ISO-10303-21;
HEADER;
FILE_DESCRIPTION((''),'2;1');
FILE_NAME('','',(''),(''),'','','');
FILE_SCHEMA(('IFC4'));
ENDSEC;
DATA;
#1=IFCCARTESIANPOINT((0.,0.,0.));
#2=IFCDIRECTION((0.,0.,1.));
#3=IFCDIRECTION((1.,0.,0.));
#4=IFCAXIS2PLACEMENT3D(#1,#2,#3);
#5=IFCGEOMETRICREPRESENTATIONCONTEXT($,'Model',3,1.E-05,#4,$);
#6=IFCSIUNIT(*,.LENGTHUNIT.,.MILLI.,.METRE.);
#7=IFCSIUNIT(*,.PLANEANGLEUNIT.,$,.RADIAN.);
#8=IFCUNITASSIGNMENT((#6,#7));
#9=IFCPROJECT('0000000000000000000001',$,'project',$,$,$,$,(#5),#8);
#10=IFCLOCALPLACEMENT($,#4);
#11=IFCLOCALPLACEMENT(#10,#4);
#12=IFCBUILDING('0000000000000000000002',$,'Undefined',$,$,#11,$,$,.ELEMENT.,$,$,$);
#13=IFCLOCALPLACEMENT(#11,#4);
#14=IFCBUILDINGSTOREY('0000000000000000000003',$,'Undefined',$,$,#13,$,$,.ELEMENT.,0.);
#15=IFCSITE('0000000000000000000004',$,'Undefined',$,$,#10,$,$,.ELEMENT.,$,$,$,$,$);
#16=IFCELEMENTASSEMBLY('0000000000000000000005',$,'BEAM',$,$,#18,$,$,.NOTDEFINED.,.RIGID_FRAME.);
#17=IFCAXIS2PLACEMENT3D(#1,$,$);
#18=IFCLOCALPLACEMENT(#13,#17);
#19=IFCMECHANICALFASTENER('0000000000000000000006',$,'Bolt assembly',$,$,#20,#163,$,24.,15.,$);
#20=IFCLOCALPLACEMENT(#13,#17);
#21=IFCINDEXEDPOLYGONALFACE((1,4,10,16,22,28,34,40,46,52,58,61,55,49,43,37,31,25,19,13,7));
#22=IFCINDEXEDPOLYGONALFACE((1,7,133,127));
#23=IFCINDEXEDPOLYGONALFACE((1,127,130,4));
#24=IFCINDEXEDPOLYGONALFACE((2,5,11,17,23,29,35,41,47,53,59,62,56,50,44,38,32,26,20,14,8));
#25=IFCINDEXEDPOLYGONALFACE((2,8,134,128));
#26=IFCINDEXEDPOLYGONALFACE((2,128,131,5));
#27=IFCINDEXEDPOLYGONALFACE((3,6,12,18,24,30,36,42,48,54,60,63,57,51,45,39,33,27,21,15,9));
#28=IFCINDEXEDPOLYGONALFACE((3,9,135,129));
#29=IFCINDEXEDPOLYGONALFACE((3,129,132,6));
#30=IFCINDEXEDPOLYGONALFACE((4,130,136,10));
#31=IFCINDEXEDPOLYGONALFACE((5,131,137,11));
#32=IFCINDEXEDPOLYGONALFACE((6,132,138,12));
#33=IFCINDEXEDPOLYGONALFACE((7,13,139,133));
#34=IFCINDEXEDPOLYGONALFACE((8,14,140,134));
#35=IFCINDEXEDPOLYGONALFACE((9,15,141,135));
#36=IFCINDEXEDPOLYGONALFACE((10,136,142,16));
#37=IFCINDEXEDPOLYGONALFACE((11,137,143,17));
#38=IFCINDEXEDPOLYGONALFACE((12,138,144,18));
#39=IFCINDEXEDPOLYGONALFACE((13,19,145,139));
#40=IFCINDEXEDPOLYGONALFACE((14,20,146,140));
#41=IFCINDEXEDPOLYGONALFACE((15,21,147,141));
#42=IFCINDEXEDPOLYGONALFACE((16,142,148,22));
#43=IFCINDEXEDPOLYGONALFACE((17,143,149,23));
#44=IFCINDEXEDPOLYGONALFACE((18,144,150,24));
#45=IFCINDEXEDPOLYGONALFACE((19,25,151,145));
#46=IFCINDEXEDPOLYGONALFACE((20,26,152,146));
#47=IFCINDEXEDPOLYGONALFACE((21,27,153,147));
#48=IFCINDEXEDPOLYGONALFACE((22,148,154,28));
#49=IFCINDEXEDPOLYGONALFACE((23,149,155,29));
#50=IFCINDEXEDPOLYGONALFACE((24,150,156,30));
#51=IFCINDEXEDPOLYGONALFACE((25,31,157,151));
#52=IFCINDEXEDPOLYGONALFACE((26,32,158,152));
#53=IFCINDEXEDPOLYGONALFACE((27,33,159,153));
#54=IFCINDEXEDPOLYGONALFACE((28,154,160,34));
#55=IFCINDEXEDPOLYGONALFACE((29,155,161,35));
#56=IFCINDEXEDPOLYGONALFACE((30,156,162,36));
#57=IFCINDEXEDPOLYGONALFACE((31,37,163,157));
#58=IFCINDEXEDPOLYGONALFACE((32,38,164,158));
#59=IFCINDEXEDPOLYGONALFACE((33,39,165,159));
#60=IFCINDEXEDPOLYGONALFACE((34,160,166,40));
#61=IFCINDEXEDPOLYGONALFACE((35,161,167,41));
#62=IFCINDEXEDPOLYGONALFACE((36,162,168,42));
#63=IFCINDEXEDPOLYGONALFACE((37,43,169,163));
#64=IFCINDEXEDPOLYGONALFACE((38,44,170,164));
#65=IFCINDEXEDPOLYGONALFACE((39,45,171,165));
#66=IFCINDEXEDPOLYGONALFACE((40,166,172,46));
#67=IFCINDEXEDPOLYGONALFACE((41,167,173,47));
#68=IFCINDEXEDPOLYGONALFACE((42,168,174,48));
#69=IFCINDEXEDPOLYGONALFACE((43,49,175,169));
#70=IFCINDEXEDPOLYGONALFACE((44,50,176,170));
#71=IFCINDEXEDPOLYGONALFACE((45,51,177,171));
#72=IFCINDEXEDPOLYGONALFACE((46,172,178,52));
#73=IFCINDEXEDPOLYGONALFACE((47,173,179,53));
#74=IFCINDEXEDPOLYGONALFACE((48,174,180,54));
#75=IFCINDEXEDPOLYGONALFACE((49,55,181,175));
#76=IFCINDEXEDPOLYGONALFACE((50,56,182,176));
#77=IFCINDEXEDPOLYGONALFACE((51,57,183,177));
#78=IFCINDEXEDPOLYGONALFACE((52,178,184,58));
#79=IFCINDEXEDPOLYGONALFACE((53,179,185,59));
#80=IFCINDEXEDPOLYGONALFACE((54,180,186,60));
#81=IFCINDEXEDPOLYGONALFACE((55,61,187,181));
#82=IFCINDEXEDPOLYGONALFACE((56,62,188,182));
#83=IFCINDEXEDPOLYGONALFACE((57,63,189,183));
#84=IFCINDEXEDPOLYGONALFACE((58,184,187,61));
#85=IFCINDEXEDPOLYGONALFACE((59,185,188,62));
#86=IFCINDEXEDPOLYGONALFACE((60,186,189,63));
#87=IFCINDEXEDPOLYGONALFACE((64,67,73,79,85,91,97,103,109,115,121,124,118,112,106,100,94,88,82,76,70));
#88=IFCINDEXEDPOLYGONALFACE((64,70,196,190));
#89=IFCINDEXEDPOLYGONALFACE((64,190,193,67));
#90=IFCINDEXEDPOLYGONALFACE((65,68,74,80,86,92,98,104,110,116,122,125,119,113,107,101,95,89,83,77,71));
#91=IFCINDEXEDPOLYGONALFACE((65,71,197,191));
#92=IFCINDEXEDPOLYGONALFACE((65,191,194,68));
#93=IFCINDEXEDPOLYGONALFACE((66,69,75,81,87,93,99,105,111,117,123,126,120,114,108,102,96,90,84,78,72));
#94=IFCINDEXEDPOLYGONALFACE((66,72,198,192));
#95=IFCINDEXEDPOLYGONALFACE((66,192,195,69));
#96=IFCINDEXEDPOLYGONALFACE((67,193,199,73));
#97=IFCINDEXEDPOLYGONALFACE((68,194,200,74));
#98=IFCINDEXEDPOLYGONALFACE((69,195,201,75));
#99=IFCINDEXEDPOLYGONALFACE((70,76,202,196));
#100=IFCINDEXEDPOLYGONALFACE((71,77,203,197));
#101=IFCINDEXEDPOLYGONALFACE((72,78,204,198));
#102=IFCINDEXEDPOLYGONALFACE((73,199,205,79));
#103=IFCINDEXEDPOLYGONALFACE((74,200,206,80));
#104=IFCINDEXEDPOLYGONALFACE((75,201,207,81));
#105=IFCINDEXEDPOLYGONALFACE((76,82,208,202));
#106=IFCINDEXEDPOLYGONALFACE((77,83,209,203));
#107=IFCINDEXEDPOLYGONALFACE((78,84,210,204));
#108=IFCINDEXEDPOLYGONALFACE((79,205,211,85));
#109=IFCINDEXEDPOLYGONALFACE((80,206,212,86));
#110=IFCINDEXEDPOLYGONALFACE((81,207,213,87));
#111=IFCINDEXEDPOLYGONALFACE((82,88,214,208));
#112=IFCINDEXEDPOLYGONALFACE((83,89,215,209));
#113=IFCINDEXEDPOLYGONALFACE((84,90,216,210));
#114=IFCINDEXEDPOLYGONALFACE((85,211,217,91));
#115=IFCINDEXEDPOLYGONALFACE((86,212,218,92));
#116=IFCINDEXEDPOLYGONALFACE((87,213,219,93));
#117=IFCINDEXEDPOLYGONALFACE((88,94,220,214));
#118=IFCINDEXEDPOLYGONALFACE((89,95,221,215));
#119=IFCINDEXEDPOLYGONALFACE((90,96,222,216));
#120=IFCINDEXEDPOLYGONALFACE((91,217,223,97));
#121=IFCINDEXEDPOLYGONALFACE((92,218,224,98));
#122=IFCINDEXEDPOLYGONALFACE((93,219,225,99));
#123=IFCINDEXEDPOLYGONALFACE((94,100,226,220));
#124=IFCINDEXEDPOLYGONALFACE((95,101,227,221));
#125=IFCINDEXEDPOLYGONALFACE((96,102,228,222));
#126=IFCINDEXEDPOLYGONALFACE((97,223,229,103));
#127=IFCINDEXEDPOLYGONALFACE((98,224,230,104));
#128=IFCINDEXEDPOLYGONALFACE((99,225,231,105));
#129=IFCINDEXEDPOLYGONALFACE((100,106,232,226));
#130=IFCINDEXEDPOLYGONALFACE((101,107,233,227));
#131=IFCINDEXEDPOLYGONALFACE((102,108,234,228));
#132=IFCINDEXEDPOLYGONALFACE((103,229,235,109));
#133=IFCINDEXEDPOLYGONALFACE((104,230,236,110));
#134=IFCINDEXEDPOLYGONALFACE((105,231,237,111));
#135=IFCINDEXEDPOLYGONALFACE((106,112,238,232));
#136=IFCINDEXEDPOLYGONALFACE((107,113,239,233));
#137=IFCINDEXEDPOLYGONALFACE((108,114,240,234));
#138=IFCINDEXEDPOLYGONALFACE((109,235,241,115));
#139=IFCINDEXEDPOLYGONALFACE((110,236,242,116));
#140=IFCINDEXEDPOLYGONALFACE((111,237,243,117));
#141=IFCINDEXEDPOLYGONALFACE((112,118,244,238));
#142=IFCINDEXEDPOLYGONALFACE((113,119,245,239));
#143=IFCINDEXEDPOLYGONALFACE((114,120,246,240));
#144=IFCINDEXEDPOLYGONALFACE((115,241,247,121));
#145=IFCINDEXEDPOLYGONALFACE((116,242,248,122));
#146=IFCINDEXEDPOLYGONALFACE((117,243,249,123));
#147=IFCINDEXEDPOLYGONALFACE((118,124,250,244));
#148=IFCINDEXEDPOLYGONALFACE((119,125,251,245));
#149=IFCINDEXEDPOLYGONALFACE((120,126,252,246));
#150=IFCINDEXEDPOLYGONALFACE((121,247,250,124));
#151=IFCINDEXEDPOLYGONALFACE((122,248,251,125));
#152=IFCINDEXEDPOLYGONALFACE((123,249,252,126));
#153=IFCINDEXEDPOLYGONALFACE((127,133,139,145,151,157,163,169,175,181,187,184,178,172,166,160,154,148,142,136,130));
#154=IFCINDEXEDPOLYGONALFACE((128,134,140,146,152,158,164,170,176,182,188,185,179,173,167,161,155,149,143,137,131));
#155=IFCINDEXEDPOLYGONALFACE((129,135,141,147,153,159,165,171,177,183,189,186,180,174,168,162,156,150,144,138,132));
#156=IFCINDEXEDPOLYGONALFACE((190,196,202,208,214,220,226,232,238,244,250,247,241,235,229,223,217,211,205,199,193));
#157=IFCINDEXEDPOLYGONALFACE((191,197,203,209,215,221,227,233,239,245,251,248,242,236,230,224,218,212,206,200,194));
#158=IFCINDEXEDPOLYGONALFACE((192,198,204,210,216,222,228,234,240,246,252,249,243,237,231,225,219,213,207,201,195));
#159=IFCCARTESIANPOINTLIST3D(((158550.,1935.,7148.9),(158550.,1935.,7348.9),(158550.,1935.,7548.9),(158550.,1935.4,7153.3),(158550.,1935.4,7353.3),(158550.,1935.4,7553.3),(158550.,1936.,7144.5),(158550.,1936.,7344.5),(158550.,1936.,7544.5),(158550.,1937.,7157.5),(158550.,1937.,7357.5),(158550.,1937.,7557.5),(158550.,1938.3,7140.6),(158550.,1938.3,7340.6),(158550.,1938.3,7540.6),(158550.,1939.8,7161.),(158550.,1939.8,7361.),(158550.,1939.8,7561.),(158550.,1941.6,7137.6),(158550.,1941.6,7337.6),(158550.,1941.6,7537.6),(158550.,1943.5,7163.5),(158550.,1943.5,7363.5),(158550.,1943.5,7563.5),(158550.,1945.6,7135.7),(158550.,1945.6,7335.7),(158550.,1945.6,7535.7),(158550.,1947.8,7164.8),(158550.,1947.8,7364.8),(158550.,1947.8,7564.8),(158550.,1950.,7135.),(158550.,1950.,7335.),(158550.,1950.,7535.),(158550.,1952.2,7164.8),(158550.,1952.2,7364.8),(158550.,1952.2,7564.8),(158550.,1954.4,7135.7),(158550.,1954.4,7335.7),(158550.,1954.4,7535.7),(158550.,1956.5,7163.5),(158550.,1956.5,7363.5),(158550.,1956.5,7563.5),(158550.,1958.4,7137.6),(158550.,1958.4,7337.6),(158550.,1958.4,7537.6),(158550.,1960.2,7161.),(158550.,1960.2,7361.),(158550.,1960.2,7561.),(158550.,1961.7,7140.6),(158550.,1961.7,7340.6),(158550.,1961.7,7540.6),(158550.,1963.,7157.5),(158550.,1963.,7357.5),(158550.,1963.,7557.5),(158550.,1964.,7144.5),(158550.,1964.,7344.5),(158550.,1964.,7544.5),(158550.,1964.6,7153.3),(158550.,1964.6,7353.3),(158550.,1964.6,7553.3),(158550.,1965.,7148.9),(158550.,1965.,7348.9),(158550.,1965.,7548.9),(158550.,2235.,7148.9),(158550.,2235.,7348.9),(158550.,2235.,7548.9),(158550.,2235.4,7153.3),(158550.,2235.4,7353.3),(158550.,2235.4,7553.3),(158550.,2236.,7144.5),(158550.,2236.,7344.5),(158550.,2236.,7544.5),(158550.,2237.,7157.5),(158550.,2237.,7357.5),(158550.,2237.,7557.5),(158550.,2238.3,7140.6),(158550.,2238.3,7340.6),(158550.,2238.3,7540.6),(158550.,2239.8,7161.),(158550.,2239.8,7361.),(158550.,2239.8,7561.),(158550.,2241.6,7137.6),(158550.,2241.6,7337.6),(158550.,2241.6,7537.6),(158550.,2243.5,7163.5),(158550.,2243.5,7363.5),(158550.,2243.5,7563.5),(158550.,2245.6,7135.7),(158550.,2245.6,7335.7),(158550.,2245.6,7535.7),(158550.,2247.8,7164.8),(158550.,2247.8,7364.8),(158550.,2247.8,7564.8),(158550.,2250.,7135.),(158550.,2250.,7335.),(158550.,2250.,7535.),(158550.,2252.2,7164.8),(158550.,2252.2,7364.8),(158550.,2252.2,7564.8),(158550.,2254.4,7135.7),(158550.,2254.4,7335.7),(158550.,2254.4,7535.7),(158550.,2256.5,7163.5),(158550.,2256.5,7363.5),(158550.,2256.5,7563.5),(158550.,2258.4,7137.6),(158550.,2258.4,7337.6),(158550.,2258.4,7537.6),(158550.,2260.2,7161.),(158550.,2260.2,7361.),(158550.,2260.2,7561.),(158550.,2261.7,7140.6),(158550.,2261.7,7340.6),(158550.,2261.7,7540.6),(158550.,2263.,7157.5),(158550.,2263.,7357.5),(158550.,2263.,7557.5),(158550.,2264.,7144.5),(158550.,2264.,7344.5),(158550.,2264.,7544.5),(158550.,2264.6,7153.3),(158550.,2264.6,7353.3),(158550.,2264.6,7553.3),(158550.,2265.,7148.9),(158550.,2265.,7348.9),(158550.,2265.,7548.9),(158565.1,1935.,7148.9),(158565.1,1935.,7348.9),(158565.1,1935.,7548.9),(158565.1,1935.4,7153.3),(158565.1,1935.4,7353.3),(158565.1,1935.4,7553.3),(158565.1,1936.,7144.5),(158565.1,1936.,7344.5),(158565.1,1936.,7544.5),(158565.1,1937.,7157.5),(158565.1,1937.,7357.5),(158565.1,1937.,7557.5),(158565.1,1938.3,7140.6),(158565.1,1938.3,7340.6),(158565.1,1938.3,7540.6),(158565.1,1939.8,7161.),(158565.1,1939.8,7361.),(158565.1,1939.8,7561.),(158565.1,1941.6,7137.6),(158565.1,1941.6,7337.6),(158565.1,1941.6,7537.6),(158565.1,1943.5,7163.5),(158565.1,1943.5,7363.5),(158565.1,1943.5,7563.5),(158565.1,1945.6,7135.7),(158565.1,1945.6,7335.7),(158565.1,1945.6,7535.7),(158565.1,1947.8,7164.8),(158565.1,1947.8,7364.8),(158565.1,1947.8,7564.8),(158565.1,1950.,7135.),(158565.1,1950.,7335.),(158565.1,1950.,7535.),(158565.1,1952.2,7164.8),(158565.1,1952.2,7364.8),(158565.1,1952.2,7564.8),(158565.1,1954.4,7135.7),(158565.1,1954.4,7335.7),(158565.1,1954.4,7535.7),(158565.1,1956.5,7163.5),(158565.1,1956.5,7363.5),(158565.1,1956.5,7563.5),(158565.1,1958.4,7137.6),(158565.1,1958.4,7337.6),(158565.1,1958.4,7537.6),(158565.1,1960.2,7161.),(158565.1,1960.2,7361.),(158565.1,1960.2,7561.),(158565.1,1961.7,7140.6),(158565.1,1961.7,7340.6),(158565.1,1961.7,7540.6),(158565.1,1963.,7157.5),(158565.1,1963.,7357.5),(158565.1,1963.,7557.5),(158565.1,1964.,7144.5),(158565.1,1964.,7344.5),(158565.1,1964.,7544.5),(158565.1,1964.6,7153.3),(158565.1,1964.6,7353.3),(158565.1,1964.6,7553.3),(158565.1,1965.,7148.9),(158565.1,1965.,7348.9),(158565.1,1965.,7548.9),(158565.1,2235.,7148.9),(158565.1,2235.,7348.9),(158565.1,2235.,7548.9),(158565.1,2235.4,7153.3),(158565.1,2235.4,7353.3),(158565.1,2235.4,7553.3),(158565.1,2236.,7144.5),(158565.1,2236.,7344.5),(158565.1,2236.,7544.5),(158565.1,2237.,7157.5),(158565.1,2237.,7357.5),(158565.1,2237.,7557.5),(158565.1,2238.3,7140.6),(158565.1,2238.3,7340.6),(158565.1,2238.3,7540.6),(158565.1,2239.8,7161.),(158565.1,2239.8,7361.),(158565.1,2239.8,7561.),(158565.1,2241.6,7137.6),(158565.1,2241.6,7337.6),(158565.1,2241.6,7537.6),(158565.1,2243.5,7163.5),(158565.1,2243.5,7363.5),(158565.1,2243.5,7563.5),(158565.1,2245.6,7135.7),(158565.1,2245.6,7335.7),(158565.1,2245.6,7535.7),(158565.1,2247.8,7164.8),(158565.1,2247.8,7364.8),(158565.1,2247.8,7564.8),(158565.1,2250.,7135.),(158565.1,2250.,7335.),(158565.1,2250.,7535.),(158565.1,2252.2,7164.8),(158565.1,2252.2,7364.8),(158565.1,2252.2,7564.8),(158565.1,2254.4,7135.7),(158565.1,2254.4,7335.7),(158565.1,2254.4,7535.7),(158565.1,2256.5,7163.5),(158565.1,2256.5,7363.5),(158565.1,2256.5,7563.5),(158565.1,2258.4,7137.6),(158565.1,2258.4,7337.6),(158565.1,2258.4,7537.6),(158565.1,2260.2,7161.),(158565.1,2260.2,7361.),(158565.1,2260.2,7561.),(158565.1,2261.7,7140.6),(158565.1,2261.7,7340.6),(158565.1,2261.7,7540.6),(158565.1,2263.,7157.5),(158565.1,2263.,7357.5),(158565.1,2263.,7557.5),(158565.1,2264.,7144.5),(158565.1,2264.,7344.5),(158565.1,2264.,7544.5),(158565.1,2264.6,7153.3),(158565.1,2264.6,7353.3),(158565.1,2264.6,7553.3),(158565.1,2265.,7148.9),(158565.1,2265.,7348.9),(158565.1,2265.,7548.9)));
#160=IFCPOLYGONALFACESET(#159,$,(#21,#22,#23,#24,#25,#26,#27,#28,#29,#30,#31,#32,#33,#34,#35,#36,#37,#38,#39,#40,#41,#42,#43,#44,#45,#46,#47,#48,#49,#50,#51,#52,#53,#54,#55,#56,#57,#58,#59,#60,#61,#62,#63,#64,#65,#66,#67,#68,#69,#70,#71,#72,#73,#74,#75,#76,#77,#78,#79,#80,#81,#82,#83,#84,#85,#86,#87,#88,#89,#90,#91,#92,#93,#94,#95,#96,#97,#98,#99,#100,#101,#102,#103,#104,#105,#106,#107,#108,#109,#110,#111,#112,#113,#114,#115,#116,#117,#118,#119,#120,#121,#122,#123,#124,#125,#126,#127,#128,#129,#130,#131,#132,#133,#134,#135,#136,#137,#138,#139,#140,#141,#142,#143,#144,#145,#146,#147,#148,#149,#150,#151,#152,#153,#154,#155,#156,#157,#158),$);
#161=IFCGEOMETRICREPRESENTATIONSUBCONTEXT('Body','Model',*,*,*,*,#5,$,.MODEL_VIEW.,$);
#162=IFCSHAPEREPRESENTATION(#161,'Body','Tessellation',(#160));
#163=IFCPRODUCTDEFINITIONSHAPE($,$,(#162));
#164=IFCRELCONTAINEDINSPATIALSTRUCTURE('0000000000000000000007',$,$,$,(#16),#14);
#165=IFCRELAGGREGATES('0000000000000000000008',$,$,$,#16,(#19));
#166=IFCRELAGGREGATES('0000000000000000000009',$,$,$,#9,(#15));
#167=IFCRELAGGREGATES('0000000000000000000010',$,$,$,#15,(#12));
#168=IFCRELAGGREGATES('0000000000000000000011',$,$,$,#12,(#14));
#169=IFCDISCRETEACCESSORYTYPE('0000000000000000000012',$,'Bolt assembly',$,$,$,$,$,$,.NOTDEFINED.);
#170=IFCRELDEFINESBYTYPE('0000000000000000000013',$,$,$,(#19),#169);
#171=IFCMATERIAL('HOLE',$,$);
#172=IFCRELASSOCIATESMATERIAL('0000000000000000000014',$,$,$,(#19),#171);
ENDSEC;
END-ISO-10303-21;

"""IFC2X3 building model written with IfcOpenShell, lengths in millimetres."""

from ifc_helpers import new_model, si_unit, frame, origin_with_axes, origin_2d_with_axis, place, context, subcontext, project, spatial, circle, extrude, source, transform, mapped, material, type_object, element, aggregate, save


model = new_model("IFC2X3")

# Units and contexts
model_context = context("Model", 3, precision=1e-05, world=origin_with_axes())
body_context = subcontext(model_context, "Body", "Model", "MODEL_VIEW")
ifc_project = project(units=[si_unit("LENGTHUNIT", "METRE", prefix="MILLI"), si_unit("PLANEANGLEUNIT", "RADIAN")], contexts=[model_context])

# Site, building, storey
site_placement = place(None, origin_with_axes())
site = spatial("IfcSite", under=ifc_project, at=site_placement, Name="Undefined", CompositionType="ELEMENT")
building_placement = place(site_placement, origin_with_axes())
building = spatial("IfcBuilding", under=site, at=building_placement, Name="Undefined", CompositionType="ELEMENT")
storey_placement = place(building_placement, origin_with_axes())
storey = spatial("IfcBuildingStorey", under=building, at=storey_placement, Name="Undefined", CompositionType="ELEMENT", Elevation=0.0)

# Element assembly
assembly_1_placement = place(storey_placement, origin_with_axes())
assembly_1 = element("IfcElementAssembly", 1, at=assembly_1_placement, inside=storey, Name="BEAM", AssemblyPlace="NOTDEFINED", PredefinedType="RIGID_FRAME")

# Mechanical fastener
ifc_material_1 = material(Name="HOLE")
discrete_accessory_type_1 = type_object("IfcDiscreteAccessoryType", Name="Bolt assembly")
shared_shape_1 = source(origin_with_axes(), body_context, "Body", "SweptSolid", [
    extrude(circle(Radius=15.0, at=origin_2d_with_axis()), frame((0.0, -15.0, 0.0), z_axis=(0.0, 1.0, 0.0), x_axis=(1.0, 0.0, 0.0)), (0.0, 0.0, 1.0), 15.1),
])
mechanical_fastener_1_placement = place(assembly_1_placement, frame((158565.0, 2100.0, 7550.0), z_axis=(0.0, -1.0, 0.0), x_axis=(0.0, 0.0, -1.0)))
mechanical_fastener_1 = element("IfcMechanicalFastener", 2, at=mechanical_fastener_1_placement, type_object=discrete_accessory_type_1, material=ifc_material_1, Name="Bolt assembly", NominalDiameter=24.0, NominalLength=15.0, context=body_context, shape_type="MappedRepresentation", body=[
    mapped(shared_shape_1, transform((0.0, 0.0, -150.0))),
    mapped(shared_shape_1, transform((0.0, 0.0, 150.0))),
    mapped(shared_shape_1, transform((200.0, 0.0, -150.0))),
    mapped(shared_shape_1, transform((200.0, 0.0, 150.0))),
    mapped(shared_shape_1, transform((400.0, 0.0, -150.0))),
    mapped(shared_shape_1, transform((400.0, 0.0, 150.0))),
])
aggregate(assembly_1, [mechanical_fastener_1])

save(model, "model.ifc")
